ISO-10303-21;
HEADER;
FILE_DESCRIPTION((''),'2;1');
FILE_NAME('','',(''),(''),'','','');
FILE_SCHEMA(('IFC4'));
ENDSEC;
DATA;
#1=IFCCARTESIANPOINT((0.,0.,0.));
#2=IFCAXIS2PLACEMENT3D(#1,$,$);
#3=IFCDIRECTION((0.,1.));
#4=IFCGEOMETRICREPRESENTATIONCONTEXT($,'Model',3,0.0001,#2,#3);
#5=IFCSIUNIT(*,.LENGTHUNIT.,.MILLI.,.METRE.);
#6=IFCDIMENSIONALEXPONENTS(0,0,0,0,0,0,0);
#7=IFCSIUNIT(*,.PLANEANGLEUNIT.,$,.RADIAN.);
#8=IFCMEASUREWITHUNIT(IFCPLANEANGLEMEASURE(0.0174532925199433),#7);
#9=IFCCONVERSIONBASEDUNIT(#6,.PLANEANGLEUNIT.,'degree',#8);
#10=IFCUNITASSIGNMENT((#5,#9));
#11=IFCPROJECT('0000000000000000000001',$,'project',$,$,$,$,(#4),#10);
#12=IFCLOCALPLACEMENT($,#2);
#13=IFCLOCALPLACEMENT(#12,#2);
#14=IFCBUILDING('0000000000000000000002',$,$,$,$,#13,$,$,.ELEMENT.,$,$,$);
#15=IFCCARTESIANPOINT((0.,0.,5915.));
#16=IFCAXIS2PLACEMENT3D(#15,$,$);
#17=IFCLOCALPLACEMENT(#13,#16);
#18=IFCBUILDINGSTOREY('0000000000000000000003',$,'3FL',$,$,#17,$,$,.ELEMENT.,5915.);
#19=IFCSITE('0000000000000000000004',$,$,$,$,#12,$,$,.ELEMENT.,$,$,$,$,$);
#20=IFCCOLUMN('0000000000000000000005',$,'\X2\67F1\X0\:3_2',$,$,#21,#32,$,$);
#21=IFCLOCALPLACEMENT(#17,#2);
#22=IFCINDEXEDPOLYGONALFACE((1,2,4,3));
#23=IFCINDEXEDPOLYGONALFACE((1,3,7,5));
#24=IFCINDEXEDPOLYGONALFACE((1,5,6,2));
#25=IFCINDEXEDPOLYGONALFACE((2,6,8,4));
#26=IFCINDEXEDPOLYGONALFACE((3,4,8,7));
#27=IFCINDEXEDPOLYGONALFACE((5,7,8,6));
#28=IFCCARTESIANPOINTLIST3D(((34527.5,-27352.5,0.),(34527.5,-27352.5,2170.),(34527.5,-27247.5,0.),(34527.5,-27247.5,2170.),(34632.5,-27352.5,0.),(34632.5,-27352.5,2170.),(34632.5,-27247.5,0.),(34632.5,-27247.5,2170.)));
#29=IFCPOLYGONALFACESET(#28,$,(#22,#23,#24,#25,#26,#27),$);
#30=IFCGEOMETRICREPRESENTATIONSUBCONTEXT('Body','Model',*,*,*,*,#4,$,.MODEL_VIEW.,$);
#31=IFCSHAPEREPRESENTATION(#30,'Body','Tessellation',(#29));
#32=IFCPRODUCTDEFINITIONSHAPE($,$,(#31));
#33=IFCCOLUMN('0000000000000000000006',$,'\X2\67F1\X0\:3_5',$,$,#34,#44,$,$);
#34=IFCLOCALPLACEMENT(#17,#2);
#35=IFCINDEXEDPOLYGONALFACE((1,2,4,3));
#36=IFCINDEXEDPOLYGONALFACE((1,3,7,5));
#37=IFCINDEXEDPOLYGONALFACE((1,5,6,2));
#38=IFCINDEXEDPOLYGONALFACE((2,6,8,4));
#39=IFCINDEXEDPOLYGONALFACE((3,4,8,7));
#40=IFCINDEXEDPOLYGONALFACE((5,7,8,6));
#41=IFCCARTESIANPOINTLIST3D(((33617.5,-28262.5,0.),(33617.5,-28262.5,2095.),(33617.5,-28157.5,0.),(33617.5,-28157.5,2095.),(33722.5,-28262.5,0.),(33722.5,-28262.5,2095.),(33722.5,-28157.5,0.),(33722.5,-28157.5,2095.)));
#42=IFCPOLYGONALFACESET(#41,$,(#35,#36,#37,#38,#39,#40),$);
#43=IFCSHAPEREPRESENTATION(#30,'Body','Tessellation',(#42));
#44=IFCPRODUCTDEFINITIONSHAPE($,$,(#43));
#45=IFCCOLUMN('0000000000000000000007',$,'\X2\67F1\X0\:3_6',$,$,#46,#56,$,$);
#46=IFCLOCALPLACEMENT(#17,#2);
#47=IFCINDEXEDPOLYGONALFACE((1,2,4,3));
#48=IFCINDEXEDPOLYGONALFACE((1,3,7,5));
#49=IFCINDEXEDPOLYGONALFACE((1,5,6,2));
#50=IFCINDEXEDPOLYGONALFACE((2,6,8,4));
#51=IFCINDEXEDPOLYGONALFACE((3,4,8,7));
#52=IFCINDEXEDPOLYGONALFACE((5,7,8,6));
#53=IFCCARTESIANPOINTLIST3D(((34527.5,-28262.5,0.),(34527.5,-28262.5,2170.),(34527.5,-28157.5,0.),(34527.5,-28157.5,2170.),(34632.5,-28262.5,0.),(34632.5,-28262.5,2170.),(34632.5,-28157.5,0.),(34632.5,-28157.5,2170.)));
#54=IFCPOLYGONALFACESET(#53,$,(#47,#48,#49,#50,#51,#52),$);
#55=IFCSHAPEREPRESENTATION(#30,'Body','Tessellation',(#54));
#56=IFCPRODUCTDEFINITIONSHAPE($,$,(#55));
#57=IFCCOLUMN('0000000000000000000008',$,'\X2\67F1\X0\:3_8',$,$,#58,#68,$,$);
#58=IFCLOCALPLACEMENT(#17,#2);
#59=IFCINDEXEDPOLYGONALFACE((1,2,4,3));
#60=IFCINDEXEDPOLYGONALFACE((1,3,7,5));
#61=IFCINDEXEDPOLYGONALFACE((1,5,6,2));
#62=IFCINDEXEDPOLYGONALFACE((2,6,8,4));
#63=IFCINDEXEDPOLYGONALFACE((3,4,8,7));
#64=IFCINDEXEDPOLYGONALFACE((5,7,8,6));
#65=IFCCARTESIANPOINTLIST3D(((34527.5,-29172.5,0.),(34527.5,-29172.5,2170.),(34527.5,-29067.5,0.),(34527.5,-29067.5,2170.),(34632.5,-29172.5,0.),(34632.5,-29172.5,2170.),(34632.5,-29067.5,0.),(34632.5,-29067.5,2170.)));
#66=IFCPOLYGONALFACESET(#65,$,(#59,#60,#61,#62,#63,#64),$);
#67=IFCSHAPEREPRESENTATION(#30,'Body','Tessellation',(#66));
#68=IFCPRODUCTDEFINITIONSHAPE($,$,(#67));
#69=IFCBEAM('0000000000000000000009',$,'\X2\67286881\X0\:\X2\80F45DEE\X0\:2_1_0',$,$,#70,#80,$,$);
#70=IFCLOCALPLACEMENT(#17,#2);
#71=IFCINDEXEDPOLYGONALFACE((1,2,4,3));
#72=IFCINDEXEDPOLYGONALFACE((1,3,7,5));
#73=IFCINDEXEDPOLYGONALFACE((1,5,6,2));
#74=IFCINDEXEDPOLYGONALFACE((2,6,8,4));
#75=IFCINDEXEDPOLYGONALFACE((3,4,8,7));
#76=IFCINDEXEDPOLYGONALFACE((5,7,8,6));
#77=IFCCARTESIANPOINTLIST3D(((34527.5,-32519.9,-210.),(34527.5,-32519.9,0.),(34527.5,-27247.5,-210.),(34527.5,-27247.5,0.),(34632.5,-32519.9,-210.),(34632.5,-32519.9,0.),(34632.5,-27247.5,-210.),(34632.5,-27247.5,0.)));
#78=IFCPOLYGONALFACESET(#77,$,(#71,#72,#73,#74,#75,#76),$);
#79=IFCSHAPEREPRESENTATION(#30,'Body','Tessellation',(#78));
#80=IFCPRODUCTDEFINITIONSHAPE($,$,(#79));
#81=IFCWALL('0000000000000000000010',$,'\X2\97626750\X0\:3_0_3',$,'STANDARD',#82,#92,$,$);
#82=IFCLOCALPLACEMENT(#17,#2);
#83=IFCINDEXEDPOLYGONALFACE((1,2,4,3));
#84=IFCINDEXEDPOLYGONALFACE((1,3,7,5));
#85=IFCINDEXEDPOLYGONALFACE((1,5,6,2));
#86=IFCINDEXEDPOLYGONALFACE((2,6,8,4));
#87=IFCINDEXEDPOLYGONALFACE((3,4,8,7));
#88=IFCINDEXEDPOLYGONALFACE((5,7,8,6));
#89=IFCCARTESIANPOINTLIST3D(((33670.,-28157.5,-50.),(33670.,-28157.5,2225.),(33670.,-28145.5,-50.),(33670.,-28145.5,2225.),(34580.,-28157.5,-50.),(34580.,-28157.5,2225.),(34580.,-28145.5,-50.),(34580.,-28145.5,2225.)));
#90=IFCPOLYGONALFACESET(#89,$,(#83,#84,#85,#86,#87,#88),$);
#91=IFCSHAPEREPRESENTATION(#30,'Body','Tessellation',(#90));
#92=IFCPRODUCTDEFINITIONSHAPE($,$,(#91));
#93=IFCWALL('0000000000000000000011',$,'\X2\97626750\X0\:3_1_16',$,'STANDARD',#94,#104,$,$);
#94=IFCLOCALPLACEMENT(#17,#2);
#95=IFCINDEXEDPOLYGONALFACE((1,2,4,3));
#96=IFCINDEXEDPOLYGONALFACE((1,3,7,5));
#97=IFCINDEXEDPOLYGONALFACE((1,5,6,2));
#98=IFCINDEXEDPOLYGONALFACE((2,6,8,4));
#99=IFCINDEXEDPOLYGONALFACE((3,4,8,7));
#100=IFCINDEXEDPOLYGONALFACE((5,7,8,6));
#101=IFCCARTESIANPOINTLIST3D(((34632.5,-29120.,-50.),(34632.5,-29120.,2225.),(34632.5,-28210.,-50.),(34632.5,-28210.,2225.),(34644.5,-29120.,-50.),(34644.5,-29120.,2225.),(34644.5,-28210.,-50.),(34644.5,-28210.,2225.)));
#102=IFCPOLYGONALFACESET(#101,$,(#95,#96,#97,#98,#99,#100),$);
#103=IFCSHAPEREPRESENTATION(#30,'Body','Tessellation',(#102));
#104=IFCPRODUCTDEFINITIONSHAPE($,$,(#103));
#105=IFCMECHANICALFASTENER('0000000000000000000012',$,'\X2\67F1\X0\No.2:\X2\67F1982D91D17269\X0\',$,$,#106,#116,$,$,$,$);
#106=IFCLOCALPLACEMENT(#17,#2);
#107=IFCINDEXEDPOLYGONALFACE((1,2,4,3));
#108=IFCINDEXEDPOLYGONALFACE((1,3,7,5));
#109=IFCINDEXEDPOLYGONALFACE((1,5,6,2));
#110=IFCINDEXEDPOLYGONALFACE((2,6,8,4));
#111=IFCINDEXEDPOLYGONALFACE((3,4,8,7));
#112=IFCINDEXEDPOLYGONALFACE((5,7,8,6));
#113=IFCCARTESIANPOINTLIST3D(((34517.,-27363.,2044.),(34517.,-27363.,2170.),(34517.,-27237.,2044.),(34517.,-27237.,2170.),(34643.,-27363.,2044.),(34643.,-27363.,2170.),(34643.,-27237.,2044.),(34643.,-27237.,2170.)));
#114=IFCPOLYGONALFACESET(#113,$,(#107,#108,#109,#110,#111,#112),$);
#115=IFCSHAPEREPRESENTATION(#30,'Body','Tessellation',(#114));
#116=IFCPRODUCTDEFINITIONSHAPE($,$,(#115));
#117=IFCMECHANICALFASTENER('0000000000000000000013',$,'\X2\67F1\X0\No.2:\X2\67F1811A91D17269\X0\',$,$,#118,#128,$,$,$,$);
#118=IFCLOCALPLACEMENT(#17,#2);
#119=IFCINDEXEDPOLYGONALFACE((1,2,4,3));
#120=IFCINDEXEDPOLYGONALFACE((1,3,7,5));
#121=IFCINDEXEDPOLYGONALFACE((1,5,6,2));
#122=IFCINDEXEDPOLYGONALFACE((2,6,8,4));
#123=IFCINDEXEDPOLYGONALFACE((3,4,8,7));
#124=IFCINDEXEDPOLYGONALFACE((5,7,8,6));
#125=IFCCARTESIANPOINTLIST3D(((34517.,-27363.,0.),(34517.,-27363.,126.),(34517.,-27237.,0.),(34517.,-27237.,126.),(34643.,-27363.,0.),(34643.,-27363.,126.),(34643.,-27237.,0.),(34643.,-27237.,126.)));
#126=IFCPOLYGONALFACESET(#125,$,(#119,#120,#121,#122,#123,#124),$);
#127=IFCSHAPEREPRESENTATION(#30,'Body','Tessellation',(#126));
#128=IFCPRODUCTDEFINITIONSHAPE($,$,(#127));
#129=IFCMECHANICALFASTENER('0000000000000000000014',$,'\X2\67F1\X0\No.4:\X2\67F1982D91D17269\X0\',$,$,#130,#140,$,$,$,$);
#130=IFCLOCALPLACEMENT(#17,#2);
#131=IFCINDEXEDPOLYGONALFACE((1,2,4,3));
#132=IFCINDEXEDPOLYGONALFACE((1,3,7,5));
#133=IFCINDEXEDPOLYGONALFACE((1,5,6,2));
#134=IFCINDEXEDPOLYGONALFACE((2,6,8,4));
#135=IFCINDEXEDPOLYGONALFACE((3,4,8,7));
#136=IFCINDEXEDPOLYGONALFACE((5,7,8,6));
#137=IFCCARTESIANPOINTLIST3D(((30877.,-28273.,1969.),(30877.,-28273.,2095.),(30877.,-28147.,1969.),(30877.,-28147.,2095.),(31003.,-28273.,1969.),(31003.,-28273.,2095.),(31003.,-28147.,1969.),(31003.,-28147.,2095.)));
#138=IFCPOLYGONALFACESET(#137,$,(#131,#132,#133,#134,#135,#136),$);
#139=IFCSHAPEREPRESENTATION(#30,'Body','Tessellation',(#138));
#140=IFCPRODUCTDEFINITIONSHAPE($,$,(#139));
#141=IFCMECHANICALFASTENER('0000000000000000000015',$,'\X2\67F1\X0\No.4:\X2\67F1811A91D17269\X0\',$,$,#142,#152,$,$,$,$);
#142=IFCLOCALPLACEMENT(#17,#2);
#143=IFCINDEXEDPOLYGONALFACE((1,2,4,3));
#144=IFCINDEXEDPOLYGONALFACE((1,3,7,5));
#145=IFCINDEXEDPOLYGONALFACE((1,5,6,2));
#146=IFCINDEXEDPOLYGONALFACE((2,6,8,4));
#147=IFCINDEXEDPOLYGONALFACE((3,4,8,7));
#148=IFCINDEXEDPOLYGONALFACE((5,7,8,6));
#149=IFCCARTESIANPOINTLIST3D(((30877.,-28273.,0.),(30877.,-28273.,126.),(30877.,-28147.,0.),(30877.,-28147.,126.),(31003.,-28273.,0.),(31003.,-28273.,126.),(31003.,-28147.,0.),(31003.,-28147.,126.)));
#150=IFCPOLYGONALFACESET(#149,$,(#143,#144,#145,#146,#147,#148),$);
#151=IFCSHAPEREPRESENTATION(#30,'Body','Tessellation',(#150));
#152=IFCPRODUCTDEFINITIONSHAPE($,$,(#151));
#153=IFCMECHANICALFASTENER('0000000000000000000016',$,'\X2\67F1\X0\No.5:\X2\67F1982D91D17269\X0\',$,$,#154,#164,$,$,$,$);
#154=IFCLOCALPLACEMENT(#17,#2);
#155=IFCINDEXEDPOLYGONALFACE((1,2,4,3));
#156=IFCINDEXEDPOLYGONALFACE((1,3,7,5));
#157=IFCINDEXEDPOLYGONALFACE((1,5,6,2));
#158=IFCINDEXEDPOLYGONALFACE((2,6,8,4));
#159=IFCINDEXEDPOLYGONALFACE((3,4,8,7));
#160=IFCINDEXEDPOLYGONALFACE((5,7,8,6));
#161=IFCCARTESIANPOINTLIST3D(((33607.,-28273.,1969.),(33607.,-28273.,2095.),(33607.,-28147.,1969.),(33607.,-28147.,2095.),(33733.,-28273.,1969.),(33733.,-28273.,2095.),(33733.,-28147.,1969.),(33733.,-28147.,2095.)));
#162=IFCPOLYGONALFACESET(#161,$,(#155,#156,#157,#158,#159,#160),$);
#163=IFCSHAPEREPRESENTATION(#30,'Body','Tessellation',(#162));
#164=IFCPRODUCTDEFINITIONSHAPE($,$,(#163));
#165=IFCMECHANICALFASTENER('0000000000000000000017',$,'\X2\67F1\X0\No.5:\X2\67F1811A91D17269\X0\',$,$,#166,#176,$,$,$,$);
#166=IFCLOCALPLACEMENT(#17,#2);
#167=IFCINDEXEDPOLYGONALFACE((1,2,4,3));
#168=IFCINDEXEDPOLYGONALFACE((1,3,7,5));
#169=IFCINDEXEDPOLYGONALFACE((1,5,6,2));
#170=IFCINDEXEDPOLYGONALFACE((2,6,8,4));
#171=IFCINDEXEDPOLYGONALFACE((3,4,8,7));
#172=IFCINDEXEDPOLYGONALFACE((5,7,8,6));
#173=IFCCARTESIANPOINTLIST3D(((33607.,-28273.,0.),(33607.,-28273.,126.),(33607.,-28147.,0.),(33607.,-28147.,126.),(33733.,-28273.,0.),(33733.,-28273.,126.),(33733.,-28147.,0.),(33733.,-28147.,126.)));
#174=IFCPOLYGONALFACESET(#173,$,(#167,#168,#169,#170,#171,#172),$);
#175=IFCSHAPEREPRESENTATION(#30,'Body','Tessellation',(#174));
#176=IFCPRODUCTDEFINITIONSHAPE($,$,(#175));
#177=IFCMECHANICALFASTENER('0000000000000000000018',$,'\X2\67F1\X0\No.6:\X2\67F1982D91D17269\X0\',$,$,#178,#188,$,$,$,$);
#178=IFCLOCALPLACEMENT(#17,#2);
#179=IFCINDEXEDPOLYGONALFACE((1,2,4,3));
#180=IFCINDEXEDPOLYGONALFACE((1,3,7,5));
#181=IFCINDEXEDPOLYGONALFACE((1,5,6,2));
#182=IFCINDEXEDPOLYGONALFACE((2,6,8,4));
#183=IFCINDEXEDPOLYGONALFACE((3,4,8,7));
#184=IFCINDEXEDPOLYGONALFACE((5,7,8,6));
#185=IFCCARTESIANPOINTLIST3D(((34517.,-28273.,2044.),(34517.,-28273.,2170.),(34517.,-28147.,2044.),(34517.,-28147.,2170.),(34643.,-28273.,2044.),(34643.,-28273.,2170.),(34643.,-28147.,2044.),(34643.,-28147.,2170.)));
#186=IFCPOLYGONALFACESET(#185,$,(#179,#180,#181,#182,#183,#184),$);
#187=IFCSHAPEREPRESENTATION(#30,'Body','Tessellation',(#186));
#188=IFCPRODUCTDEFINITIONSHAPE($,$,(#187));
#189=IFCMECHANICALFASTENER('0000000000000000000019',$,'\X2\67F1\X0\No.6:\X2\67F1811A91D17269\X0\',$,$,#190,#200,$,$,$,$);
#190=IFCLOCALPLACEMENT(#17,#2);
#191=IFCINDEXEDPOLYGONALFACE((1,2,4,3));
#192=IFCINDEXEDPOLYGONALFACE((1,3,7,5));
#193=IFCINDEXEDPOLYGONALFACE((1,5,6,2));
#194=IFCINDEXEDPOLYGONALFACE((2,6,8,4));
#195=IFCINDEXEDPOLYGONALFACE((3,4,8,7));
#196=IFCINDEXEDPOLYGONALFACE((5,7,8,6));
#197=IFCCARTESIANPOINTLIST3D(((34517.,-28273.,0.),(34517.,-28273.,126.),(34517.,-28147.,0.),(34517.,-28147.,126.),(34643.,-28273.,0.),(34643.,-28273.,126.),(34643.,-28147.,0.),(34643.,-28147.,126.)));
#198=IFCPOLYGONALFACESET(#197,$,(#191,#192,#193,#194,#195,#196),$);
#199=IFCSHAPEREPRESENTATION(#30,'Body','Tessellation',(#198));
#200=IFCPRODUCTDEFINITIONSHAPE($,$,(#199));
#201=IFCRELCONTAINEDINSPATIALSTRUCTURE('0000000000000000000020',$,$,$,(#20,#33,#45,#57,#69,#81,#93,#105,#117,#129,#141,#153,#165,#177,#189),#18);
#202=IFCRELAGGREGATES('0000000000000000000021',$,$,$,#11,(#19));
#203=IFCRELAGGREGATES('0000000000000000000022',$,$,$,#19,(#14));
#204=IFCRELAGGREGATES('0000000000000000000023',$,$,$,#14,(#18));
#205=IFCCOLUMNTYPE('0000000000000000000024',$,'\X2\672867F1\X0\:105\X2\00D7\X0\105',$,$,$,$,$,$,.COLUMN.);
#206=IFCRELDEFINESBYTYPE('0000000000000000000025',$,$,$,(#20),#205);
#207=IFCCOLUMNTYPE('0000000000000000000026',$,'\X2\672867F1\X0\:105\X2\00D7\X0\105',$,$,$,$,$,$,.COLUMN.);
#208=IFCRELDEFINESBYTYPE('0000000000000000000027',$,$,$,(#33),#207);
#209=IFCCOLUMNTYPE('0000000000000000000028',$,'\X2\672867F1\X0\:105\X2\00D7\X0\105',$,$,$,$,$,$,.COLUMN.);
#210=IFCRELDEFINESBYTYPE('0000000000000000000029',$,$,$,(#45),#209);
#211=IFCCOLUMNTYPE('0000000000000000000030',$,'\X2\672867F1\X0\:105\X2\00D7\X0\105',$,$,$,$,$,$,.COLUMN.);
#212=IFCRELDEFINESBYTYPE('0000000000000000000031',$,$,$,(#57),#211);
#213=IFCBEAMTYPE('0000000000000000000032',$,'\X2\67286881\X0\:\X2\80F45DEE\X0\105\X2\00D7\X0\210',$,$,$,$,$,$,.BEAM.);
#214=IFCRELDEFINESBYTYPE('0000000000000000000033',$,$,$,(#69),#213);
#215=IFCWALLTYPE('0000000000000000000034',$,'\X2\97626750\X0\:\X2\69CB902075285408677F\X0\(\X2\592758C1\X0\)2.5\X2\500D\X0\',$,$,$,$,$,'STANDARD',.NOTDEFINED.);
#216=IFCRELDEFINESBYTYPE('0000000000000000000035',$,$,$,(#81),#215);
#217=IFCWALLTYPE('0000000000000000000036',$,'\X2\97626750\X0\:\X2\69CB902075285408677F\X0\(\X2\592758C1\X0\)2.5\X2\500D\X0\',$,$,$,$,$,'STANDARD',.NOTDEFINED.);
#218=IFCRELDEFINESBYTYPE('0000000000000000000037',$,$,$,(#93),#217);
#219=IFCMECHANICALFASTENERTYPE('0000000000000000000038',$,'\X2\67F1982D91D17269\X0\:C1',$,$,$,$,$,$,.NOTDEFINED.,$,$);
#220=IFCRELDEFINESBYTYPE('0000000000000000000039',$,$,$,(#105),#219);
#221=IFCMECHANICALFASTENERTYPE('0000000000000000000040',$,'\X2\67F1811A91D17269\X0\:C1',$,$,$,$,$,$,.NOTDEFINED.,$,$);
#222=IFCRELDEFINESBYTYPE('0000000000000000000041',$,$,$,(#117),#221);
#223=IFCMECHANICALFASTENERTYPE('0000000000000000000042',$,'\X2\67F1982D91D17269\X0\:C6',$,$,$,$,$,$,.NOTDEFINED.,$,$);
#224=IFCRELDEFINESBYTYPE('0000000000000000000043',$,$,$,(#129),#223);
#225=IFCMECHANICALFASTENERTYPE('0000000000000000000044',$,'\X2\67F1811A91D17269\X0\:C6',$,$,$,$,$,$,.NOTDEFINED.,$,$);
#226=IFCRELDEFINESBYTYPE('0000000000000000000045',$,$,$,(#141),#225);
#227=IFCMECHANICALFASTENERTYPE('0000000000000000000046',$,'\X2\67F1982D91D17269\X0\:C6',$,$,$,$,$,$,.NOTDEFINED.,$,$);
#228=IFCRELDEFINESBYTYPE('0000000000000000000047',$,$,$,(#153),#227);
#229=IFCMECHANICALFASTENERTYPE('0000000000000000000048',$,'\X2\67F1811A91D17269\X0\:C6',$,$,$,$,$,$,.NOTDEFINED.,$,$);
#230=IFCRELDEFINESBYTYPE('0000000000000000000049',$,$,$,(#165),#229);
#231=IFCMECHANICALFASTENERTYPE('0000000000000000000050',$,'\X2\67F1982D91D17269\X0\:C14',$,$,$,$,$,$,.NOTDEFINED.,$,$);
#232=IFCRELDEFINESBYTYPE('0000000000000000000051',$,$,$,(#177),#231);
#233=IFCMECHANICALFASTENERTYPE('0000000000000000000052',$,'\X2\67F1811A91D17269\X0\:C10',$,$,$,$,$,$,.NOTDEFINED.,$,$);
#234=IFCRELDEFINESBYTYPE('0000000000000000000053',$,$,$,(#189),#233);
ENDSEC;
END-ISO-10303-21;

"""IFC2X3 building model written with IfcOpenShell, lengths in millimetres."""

from ifc_helpers import new_model, entity, si_unit, converted_unit, direction, frame, origin, origin_with_axes, origin_2d, place, context, subcontext, project, spatial, polyline, rectangle, outline, extrude, type_object, element, save


model = new_model("IFC2X3")

# Units and contexts
model_context = context("Model", 3, precision=0.0001, world=origin(), true_north=direction((0.0, 1.0)))
body_context = subcontext(model_context, "Body", "Model", "MODEL_VIEW")
ifc_project = project(units=[si_unit("LENGTHUNIT", "METRE", prefix="MILLI"), converted_unit("PLANEANGLEUNIT", "degree", entity("IfcPlaneAngleMeasure", 0.0174532925199433), si_unit("PLANEANGLEUNIT", "RADIAN"), dimensions=[0, 0, 0, 0, 0, 0, 0])], contexts=[model_context])

# Site, building, storey
site_placement = place(None, origin())
site = spatial("IfcSite", under=ifc_project, at=site_placement, CompositionType="ELEMENT")
building_placement = place(site_placement, origin())
building = spatial("IfcBuilding", under=site, at=building_placement, CompositionType="ELEMENT")
storey_placement = place(building_placement, frame((0.0, 0.0, 5915.0)))
storey = spatial("IfcBuildingStorey", under=building, at=storey_placement, Name="3FL", CompositionType="ELEMENT", Elevation=5915.0)

# Columns
column_type_1 = type_object("IfcColumnType", Name="木柱:105×105", PredefinedType="COLUMN")
column_1_placement = place(storey_placement, frame((34580.0, -27300.0, 0.0)))
element("IfcColumn", 1, at=column_1_placement, inside=storey, type_object=column_type_1, Name="柱:3_2", context=body_context, shape_type="SweptSolid", body=[
    extrude(rectangle(XDim=105.0, YDim=105.0, at=origin_2d()), origin_with_axes(), (0.0, 0.0, 1.0), 2170.0),
])
column_type_2 = type_object("IfcColumnType", Name="木柱:105×105", PredefinedType="COLUMN")
column_2_placement = place(storey_placement, frame((33670.0, -28210.0, 0.0)))
element("IfcColumn", 2, at=column_2_placement, inside=storey, type_object=column_type_2, Name="柱:3_5", context=body_context, shape_type="SweptSolid", body=[
    extrude(rectangle(XDim=105.0, YDim=105.0, at=origin_2d()), origin_with_axes(), (0.0, 0.0, 1.0), 2095.0),
])
column_type_3 = type_object("IfcColumnType", Name="木柱:105×105", PredefinedType="COLUMN")
column_3_placement = place(storey_placement, frame((34580.0, -28210.0, 0.0)))
element("IfcColumn", 3, at=column_3_placement, inside=storey, type_object=column_type_3, Name="柱:3_6", context=body_context, shape_type="SweptSolid", body=[
    extrude(rectangle(XDim=105.0, YDim=105.0, at=origin_2d()), origin_with_axes(), (0.0, 0.0, 1.0), 2170.0),
])
column_type_4 = type_object("IfcColumnType", Name="木柱:105×105", PredefinedType="COLUMN")
column_4_placement = place(storey_placement, frame((34580.0, -29120.0, 0.0)))
element("IfcColumn", 4, at=column_4_placement, inside=storey, type_object=column_type_4, Name="柱:3_8", context=body_context, shape_type="SweptSolid", body=[
    extrude(rectangle(XDim=105.0, YDim=105.0, at=origin_2d()), origin_with_axes(), (0.0, 0.0, 1.0), 2170.0),
])

# Beam
beam_type = type_object("IfcBeamType", Name="木梁:胴差105×210", PredefinedType="BEAM")
beam_placement = place(storey_placement, frame((34580.0, -27247.5, -105.0), z_axis=(0.0, -1.0, 0.0), x_axis=(1.0, 0.0, 0.0)))
element("IfcBeam", 5, at=beam_placement, inside=storey, type_object=beam_type, Name="木梁:胴差:2_1_0", context=body_context, shape_type="SweptSolid", body=[
    extrude(rectangle(XDim=105.0, YDim=210.0, at=origin_2d()), origin_with_axes(), (0.0, 0.0, 1.0), 5272.4),
])

# Walls
wall_type_1 = type_object("IfcWallType", Name="面材:構造用合板(大壁)2.5倍", ElementType="STANDARD", PredefinedType="NOTDEFINED")
wall_1_placement = place(storey_placement, frame((34125.0, -28145.5, -50.0), z_axis=(0.0, -1.0, 0.0), x_axis=(1.0, 0.0, 0.0)))
element("IfcWall", 6, at=wall_1_placement, inside=storey, type_object=wall_type_1, Name="面材:3_0_3", ObjectType="STANDARD", context=body_context, shape_type="SweptSolid", body=[
    extrude(outline(polyline([(455.0, 0.0, 0.0), (-455.0, 0.0, 0.0), (-455.0, 2275.0, 0.0), (455.0, 2275.0, 0.0), (455.0, 0.0, 0.0)])), origin_with_axes(), (0.0, 0.0, 1.0), 12.0),
])
wall_type_2 = type_object("IfcWallType", Name="面材:構造用合板(大壁)2.5倍", ElementType="STANDARD", PredefinedType="NOTDEFINED")
wall_2_placement = place(storey_placement, frame((34644.5, -28665.0, -50.0), z_axis=(-1.0, 0.0, 0.0), x_axis=(0.0, -1.0, 0.0)))
element("IfcWall", 7, at=wall_2_placement, inside=storey, type_object=wall_type_2, Name="面材:3_1_16", ObjectType="STANDARD", context=body_context, shape_type="SweptSolid", body=[
    extrude(outline(polyline([(455.0, 0.0, 0.0), (-455.0, 0.0, 0.0), (-455.0, 2275.0, 0.0), (455.0, 2275.0, 0.0), (455.0, 0.0, 0.0)])), origin_with_axes(), (0.0, 0.0, 1.0), 12.0),
])

# Mechanical fasteners
mechanical_fastener_type_1 = type_object("IfcMechanicalFastenerType", Name="柱頭金物:C1")
mechanical_fastener_1_placement = place(storey_placement, frame((34580.0, -27300.0, 2044.0)))
element("IfcMechanicalFastener", 8, at=mechanical_fastener_1_placement, inside=storey, type_object=mechanical_fastener_type_1, Name="柱No.2:柱頭金物", context=body_context, shape_type="SweptSolid", body=[
    extrude(rectangle(XDim=126.0, YDim=126.0, at=origin_2d()), origin_with_axes(), (0.0, 0.0, 1.0), 126.0),
])
mechanical_fastener_type_2 = type_object("IfcMechanicalFastenerType", Name="柱脚金物:C1")
mechanical_fastener_2_placement = place(storey_placement, frame((34580.0, -27300.0, 0.0)))
element("IfcMechanicalFastener", 9, at=mechanical_fastener_2_placement, inside=storey, type_object=mechanical_fastener_type_2, Name="柱No.2:柱脚金物", context=body_context, shape_type="SweptSolid", body=[
    extrude(rectangle(XDim=126.0, YDim=126.0, at=origin_2d()), origin_with_axes(), (0.0, 0.0, 1.0), 126.0),
])
mechanical_fastener_type_3 = type_object("IfcMechanicalFastenerType", Name="柱頭金物:C6")
mechanical_fastener_3_placement = place(storey_placement, frame((30940.0, -28210.0, 1969.0)))
element("IfcMechanicalFastener", 10, at=mechanical_fastener_3_placement, inside=storey, type_object=mechanical_fastener_type_3, Name="柱No.4:柱頭金物", context=body_context, shape_type="SweptSolid", body=[
    extrude(rectangle(XDim=126.0, YDim=126.0, at=origin_2d()), origin_with_axes(), (0.0, 0.0, 1.0), 126.0),
])
mechanical_fastener_type_4 = type_object("IfcMechanicalFastenerType", Name="柱脚金物:C6")
mechanical_fastener_4_placement = place(storey_placement, frame((30940.0, -28210.0, 0.0)))
element("IfcMechanicalFastener", 11, at=mechanical_fastener_4_placement, inside=storey, type_object=mechanical_fastener_type_4, Name="柱No.4:柱脚金物", context=body_context, shape_type="SweptSolid", body=[
    extrude(rectangle(XDim=126.0, YDim=126.0, at=origin_2d()), origin_with_axes(), (0.0, 0.0, 1.0), 126.0),
])
mechanical_fastener_type_5 = type_object("IfcMechanicalFastenerType", Name="柱頭金物:C6")
mechanical_fastener_5_placement = place(storey_placement, frame((33670.0, -28210.0, 1969.0)))
element("IfcMechanicalFastener", 12, at=mechanical_fastener_5_placement, inside=storey, type_object=mechanical_fastener_type_5, Name="柱No.5:柱頭金物", context=body_context, shape_type="SweptSolid", body=[
    extrude(rectangle(XDim=126.0, YDim=126.0, at=origin_2d()), origin_with_axes(), (0.0, 0.0, 1.0), 126.0),
])
mechanical_fastener_type_6 = type_object("IfcMechanicalFastenerType", Name="柱脚金物:C6")
mechanical_fastener_6_placement = place(storey_placement, frame((33670.0, -28210.0, 0.0)))
element("IfcMechanicalFastener", 13, at=mechanical_fastener_6_placement, inside=storey, type_object=mechanical_fastener_type_6, Name="柱No.5:柱脚金物", context=body_context, shape_type="SweptSolid", body=[
    extrude(rectangle(XDim=126.0, YDim=126.0, at=origin_2d()), origin_with_axes(), (0.0, 0.0, 1.0), 126.0),
])
mechanical_fastener_type_7 = type_object("IfcMechanicalFastenerType", Name="柱頭金物:C14")
mechanical_fastener_7_placement = place(storey_placement, frame((34580.0, -28210.0, 2044.0)))
element("IfcMechanicalFastener", 14, at=mechanical_fastener_7_placement, inside=storey, type_object=mechanical_fastener_type_7, Name="柱No.6:柱頭金物", context=body_context, shape_type="SweptSolid", body=[
    extrude(rectangle(XDim=126.0, YDim=126.0, at=origin_2d()), origin_with_axes(), (0.0, 0.0, 1.0), 126.0),
])
mechanical_fastener_type_8 = type_object("IfcMechanicalFastenerType", Name="柱脚金物:C10")
mechanical_fastener_8_placement = place(storey_placement, frame((34580.0, -28210.0, 0.0)))
element("IfcMechanicalFastener", 15, at=mechanical_fastener_8_placement, inside=storey, type_object=mechanical_fastener_type_8, Name="柱No.6:柱脚金物", context=body_context, shape_type="SweptSolid", body=[
    extrude(rectangle(XDim=126.0, YDim=126.0, at=origin_2d()), origin_with_axes(), (0.0, 0.0, 1.0), 126.0),
])

save(model, "model.ifc")
